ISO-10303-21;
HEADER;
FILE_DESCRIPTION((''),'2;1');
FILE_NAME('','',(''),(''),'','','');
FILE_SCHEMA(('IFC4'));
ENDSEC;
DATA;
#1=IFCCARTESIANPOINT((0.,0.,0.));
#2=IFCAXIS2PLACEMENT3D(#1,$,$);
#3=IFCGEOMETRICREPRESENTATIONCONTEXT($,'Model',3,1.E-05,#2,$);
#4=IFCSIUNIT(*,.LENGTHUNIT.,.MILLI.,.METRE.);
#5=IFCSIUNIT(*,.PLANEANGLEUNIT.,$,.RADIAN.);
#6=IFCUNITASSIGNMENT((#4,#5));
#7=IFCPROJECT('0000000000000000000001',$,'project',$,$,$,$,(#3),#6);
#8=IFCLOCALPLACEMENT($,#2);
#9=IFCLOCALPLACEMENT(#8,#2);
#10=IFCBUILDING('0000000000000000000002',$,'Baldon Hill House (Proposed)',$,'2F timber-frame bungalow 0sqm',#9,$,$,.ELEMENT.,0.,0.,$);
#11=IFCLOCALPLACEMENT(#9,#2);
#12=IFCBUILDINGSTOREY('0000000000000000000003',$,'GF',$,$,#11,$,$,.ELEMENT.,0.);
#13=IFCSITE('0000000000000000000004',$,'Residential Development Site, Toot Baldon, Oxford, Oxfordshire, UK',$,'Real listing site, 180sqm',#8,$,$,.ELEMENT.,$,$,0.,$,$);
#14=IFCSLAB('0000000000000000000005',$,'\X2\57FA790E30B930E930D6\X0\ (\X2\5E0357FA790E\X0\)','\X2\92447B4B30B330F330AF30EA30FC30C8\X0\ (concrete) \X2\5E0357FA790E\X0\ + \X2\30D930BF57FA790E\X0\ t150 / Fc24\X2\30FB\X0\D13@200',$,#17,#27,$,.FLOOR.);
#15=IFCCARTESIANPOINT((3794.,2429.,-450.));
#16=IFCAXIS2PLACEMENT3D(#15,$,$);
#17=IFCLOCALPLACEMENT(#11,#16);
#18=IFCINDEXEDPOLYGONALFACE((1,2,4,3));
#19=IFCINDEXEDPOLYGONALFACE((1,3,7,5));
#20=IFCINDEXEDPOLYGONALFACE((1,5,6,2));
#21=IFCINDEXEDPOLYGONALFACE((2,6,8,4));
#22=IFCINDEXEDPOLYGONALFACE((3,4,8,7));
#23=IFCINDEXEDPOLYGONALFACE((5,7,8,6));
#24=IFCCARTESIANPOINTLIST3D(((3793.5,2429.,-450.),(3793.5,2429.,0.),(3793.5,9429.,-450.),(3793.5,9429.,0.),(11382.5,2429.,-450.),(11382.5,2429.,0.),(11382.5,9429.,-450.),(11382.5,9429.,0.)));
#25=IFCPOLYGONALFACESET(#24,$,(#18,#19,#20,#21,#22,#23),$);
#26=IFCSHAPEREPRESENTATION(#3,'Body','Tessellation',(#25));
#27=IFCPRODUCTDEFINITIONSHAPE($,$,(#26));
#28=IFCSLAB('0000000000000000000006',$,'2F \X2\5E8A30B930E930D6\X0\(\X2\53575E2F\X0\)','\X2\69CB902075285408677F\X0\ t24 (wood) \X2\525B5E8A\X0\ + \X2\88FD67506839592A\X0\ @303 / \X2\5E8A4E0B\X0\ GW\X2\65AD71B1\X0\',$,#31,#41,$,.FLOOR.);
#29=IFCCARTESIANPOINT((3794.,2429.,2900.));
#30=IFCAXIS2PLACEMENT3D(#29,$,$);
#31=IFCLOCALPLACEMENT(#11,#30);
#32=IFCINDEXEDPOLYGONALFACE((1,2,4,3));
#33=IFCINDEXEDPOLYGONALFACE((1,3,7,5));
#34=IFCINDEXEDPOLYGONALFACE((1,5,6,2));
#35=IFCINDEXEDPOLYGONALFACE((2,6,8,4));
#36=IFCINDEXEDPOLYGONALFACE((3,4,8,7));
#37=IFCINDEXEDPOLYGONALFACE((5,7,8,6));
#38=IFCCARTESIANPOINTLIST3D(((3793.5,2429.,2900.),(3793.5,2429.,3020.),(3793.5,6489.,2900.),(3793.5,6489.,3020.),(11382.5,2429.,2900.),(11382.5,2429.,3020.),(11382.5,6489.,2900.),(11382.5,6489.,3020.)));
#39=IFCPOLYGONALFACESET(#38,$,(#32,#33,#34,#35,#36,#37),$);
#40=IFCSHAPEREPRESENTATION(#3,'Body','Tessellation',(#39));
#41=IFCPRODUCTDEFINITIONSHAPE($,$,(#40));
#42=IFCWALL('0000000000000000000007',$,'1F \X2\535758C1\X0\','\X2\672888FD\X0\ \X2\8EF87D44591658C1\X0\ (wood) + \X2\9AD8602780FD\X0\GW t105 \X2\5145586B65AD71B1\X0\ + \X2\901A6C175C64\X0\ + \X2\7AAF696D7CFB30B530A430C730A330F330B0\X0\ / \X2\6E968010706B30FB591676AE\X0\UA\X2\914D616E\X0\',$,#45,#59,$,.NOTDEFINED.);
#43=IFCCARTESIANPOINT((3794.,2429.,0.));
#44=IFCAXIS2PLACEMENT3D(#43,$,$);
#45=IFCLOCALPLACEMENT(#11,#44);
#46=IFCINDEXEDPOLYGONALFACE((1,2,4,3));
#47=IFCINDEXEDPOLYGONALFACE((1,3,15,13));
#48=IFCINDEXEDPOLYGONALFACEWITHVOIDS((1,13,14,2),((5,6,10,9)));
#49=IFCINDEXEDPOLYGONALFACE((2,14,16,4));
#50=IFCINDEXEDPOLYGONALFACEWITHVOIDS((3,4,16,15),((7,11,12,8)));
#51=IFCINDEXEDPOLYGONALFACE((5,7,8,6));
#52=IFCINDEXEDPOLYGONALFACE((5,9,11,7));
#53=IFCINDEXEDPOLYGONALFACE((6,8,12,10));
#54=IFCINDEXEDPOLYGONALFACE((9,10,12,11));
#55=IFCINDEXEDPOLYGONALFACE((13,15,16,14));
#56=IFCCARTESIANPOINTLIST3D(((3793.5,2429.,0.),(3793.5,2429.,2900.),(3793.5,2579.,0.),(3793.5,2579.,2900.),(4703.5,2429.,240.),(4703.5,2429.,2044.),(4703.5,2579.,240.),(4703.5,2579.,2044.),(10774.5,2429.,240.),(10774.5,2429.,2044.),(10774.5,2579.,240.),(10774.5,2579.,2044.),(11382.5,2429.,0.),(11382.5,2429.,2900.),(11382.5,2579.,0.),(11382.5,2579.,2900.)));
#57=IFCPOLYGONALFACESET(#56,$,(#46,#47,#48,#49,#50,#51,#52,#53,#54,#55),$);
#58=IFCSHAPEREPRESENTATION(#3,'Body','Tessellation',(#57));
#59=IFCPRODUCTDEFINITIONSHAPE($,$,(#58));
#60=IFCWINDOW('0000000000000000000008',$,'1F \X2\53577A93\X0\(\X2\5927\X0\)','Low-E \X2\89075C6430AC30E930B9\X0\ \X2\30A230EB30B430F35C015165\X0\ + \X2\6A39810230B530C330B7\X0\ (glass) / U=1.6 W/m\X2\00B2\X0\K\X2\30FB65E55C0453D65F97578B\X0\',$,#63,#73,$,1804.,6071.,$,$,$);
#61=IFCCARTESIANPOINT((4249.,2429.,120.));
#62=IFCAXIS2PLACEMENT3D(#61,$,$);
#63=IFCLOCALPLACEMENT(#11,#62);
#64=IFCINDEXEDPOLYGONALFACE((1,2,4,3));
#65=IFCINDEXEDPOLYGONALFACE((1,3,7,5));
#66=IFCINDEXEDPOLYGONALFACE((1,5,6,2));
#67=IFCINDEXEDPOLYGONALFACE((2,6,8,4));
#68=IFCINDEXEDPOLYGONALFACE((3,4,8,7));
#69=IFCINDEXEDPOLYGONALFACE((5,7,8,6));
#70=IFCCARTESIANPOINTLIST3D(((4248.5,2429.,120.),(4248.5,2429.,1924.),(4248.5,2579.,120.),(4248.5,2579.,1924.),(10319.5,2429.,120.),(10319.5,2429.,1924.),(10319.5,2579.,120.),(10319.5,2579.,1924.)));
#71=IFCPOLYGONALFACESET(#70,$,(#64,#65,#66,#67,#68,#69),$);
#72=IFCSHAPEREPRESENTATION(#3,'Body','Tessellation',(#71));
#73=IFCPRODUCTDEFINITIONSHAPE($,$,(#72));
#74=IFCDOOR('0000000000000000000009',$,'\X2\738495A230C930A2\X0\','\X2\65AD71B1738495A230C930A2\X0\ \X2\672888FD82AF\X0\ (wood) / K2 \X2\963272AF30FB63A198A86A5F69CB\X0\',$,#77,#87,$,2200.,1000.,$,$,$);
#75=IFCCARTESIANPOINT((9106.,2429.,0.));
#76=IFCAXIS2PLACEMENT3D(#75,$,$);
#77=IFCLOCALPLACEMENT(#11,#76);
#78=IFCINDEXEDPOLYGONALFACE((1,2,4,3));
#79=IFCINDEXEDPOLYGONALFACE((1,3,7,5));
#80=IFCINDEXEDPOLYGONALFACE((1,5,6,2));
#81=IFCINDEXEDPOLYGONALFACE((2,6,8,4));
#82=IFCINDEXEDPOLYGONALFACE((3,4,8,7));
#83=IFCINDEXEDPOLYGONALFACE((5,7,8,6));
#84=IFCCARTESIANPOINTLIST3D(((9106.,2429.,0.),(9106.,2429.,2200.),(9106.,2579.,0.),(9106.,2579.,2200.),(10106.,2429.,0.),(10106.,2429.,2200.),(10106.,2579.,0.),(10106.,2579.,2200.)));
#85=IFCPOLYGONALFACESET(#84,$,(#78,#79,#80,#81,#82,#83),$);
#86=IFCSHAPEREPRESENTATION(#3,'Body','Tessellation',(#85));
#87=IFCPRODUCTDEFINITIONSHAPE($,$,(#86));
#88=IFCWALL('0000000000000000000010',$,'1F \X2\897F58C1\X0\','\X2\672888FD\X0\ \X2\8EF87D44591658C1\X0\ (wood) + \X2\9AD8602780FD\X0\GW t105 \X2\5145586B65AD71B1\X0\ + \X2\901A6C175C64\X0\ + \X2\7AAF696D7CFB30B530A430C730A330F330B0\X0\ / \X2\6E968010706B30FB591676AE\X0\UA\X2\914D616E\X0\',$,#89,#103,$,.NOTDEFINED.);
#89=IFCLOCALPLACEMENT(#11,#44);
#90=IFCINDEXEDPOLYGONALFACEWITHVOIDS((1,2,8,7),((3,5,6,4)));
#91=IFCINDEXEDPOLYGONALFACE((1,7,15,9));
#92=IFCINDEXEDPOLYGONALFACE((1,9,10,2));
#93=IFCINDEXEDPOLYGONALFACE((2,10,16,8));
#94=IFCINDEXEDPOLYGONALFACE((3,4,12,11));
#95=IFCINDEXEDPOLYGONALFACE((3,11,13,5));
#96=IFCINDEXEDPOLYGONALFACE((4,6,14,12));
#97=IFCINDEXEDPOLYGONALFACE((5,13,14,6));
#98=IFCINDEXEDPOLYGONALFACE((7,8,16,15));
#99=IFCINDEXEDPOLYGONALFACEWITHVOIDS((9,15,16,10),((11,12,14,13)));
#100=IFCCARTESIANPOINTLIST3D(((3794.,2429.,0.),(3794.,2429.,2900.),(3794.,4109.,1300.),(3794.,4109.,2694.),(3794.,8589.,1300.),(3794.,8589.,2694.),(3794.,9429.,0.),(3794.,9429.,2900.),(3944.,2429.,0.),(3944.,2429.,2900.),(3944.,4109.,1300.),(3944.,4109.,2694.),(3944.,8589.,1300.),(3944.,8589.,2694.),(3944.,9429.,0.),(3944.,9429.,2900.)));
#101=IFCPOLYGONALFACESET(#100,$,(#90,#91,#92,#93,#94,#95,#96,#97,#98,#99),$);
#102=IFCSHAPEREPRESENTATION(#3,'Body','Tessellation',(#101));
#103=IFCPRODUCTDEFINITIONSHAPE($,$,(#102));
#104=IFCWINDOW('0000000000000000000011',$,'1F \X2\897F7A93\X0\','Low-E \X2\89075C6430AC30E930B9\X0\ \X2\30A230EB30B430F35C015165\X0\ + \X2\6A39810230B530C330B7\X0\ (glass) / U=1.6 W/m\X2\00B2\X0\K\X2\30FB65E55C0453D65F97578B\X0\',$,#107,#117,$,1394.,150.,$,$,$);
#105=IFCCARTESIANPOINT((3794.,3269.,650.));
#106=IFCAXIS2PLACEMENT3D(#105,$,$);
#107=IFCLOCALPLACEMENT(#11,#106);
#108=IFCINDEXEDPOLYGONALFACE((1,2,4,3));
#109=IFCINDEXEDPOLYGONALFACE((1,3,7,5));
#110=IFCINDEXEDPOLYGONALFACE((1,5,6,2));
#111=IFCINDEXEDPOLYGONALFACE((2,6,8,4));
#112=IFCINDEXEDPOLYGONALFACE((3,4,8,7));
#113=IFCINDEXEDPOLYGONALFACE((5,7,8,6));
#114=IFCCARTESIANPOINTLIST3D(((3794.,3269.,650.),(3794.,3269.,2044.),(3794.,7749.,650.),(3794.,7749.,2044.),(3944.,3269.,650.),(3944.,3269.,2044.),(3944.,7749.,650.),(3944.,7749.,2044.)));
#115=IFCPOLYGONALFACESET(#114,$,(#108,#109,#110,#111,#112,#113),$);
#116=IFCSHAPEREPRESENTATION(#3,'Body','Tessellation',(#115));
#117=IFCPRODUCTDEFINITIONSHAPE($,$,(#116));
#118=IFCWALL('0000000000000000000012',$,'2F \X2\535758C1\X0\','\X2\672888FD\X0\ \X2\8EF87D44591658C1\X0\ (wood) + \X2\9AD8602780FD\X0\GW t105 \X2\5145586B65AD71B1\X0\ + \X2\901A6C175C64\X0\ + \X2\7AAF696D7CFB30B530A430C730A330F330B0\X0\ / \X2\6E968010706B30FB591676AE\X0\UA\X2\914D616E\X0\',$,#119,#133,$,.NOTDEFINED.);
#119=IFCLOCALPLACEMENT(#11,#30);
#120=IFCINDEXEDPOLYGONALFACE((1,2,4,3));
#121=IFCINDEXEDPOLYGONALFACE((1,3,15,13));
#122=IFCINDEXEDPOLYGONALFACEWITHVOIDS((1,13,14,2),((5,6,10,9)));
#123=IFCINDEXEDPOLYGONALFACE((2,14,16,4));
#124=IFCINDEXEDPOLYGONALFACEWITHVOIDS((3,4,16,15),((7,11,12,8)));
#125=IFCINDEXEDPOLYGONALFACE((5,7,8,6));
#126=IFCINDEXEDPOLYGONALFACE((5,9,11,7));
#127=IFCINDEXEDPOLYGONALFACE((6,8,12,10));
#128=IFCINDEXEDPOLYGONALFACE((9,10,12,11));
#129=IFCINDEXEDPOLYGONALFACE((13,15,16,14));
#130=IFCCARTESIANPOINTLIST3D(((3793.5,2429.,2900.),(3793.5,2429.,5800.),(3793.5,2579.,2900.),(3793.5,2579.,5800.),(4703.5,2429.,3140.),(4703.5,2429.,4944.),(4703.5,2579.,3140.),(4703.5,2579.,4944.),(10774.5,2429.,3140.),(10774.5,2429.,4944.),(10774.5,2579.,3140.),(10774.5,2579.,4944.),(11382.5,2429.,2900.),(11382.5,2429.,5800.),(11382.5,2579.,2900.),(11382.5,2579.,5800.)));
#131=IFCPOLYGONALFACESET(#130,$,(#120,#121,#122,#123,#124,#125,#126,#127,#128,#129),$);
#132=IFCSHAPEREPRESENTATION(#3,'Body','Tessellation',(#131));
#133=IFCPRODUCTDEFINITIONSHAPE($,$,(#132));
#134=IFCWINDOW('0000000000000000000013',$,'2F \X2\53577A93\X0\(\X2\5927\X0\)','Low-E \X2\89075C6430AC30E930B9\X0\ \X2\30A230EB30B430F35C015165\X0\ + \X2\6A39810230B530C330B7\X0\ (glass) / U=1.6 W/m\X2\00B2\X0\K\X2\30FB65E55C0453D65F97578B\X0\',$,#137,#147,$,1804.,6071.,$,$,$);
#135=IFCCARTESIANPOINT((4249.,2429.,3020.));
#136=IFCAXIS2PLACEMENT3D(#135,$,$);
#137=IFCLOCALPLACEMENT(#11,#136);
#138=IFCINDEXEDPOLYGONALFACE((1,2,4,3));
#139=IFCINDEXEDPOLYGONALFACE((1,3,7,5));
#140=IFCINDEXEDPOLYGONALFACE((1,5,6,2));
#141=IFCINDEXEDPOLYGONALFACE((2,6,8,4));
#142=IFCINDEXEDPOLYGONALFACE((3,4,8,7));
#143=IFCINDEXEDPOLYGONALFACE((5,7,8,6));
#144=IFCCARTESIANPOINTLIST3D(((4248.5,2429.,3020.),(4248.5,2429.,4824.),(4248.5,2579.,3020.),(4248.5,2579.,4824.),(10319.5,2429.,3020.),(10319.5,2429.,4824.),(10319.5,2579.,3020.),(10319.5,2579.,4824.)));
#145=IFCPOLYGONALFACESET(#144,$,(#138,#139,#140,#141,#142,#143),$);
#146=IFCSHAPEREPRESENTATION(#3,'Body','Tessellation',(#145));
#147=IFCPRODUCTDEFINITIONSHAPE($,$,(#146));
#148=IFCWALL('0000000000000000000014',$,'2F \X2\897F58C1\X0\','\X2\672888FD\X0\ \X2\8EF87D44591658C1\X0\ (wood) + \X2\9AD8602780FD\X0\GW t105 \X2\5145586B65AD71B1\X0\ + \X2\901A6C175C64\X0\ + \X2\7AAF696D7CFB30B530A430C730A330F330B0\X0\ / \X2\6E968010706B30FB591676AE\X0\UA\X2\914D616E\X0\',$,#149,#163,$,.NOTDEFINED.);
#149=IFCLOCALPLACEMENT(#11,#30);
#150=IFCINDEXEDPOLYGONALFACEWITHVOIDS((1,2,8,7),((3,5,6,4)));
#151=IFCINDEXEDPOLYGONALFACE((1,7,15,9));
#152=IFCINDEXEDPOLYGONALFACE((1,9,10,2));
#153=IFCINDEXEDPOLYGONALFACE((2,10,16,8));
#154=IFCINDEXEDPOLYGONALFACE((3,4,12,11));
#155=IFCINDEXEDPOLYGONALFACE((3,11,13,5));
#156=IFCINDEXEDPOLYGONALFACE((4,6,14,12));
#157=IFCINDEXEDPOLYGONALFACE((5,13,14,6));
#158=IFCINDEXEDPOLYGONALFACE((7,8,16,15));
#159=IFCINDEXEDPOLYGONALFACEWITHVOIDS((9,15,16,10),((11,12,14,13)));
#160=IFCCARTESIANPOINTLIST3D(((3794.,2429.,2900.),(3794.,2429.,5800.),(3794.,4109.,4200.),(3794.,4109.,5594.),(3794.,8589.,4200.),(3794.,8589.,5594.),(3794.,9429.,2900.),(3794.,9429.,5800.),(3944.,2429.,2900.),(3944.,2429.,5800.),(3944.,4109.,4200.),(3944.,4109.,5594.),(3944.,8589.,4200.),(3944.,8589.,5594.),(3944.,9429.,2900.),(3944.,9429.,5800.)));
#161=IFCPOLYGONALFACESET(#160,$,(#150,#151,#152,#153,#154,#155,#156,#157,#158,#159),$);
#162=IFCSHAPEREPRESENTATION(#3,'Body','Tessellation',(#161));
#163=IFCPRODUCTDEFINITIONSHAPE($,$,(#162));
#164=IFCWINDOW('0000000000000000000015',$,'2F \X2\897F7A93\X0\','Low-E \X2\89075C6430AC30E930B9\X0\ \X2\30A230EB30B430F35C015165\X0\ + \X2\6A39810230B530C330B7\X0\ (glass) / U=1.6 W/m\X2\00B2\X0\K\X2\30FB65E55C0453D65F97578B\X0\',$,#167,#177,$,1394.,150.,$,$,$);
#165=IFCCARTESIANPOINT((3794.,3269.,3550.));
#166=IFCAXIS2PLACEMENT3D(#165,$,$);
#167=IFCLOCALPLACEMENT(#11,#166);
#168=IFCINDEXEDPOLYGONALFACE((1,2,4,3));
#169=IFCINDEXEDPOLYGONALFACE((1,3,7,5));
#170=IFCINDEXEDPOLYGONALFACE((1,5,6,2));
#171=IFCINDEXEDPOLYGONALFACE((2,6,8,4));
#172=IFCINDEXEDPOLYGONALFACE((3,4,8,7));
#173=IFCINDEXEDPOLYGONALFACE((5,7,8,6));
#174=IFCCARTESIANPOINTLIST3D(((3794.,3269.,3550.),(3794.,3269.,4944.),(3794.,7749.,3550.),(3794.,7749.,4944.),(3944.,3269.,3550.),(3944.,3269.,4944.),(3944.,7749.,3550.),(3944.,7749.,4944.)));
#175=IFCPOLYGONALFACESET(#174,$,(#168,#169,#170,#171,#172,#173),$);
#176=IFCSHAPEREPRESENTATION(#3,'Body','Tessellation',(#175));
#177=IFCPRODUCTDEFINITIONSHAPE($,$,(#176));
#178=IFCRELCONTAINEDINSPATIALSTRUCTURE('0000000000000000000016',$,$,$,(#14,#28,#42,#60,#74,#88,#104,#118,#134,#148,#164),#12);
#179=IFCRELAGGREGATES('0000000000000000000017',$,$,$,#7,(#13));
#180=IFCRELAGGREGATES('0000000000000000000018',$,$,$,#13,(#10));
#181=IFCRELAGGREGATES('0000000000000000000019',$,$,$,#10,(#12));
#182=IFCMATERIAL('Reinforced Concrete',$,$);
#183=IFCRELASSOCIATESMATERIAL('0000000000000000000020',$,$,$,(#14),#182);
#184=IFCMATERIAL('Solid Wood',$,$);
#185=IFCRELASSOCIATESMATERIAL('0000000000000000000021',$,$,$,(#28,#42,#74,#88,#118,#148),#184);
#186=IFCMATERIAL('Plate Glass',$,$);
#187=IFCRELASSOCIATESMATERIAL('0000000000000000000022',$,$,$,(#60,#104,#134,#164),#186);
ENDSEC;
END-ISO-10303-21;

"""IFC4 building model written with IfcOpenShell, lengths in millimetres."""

from ifc_helpers import new_model, si_unit, frame, frame_2d, origin, place, context, project, spatial, rectangle, extrude, material, element, fill, save


model = new_model("IFC4")

# Units and contexts
model_context = context("Model", 3, precision=1e-05, world=origin())
ifc_project = project(units=[si_unit("LENGTHUNIT", "METRE", prefix="MILLI"), si_unit("PLANEANGLEUNIT", "RADIAN")], contexts=[model_context])

# Site, building, storey
site_placement = place(None, origin())
site = spatial("IfcSite", under=ifc_project, at=site_placement, Name="Residential Development Site, Toot Baldon, Oxford, Oxfordshire, UK", ObjectType="Real listing site, 180sqm", CompositionType="ELEMENT", RefElevation=0.0)
building_placement = place(site_placement, origin())
building = spatial("IfcBuilding", under=site, at=building_placement, Name="Baldon Hill House (Proposed)", ObjectType="2F timber-frame bungalow 0sqm", CompositionType="ELEMENT", ElevationOfRefHeight=0.0, ElevationOfTerrain=0.0)
storey_placement = place(building_placement, origin())
storey = spatial("IfcBuildingStorey", under=building, at=storey_placement, Name="GF", CompositionType="ELEMENT", Elevation=0.0)

# Slabs
ifc_material_1 = material(Name="Reinforced Concrete")
slab_1_placement = place(storey_placement, frame((3794.0, 2429.0, -450.0)))
element("IfcSlab", 1, at=slab_1_placement, inside=storey, material=ifc_material_1, Name="基礎スラブ (布基礎)", Description="鉄筋コンクリート (concrete) 布基礎 + ベタ基礎 t150 / Fc24・D13@200", PredefinedType="FLOOR", context=model_context, shape_type="SweptSolid", body=[
    extrude(rectangle(XDim=7589.0, YDim=7000.0, at=frame_2d((3794.0, 3500.0))), frame((3794.0, 2429.0, -450.0)), (0.0, 0.0, 1.0), 450.0),
])
ifc_material_2 = material(Name="Solid Wood")
slab_2_placement = place(storey_placement, frame((3794.0, 2429.0, 2900.0)))
element("IfcSlab", 2, at=slab_2_placement, inside=storey, material=ifc_material_2, Name="2F 床スラブ(南帯)", Description="構造用合板 t24 (wood) 剛床 + 製材根太 @303 / 床下 GW断熱", PredefinedType="FLOOR", context=model_context, shape_type="SweptSolid", body=[
    extrude(rectangle(XDim=7589.0, YDim=4060.0, at=frame_2d((3794.0, 2030.0))), frame((3794.0, 2429.0, 2900.0)), (0.0, 0.0, 1.0), 120.0),
])

# Wall, openings, window, door
wall_1_placement = place(storey_placement, frame((3794.0, 2429.0, 0.0)))
wall_1 = element("IfcWall", 3, at=wall_1_placement, inside=storey, material=ifc_material_2, Name="1F 南壁", Description="木製 軸組外壁 (wood) + 高性能GW t105 充填断熱 + 通気層 + 窯業系サイディング / 準耐火・外皮UA配慮", PredefinedType="NOTDEFINED", context=model_context, shape_type="SweptSolid", body=[
    extrude(rectangle(XDim=7589.0, YDim=150.0, at=frame_2d((3794.0, 75.0))), frame((3794.0, 2429.0, 0.0)), (0.0, 0.0, 1.0), 2900.0),
])
opening_1_placement = place(storey_placement, frame((4249.0, 2429.0, 120.0)))
opening_1 = element("IfcOpeningElement", 4, at=opening_1_placement, cuts=wall_1, PredefinedType="NOTDEFINED", context=model_context, shape_type="SweptSolid", body=[
    extrude(rectangle(XDim=6071.0, YDim=150.0, at=frame_2d((3035.0, 75.0))), frame((4249.0, 2429.0, 120.0)), (0.0, 0.0, 1.0), 1804.0),
])
opening_2_placement = place(storey_placement, frame((9106.0, 2429.0, 0.0)))
opening_2 = element("IfcOpeningElement", 5, at=opening_2_placement, cuts=wall_1, PredefinedType="NOTDEFINED", context=model_context, shape_type="SweptSolid", body=[
    extrude(rectangle(XDim=1000.0, YDim=150.0, at=frame_2d((500.0, 75.0))), frame((9106.0, 2429.0, 0.0)), (0.0, 0.0, 1.0), 2200.0),
])
ifc_material_3 = material(Name="Plate Glass")
window_1_placement = place(storey_placement, frame((4249.0, 2429.0, 120.0)))
window_1 = element("IfcWindow", 6, at=window_1_placement, inside=storey, material=ifc_material_3, Name="1F 南窓(大)", Description="Low-E 複層ガラス アルゴン封入 + 樹脂サッシ (glass) / U=1.6 W/m²K・日射取得型", OverallHeight=1804.0, OverallWidth=6071.0, context=model_context, shape_type="SweptSolid", body=[
    extrude(rectangle(XDim=6071.0, YDim=150.0, at=frame_2d((3035.0, 75.0))), frame((4249.0, 2429.0, 120.0)), (0.0, 0.0, 1.0), 1804.0),
])
fill(opening_1, window_1)
door_placement = place(storey_placement, frame((9106.0, 2429.0, 0.0)))
door = element("IfcDoor", 7, at=door_placement, inside=storey, material=ifc_material_2, Name="玄関ドア", Description="断熱玄関ドア 木製芯 (wood) / K2 防犯・採風機構", OverallHeight=2200.0, OverallWidth=1000.0, context=model_context, shape_type="SweptSolid", body=[
    extrude(rectangle(XDim=1000.0, YDim=150.0, at=frame_2d((500.0, 75.0))), frame((9106.0, 2429.0, 0.0)), (0.0, 0.0, 1.0), 2200.0),
])
fill(opening_2, door)

# Wall, opening, window
wall_2_placement = place(storey_placement, frame((3794.0, 2429.0, 0.0)))
wall_2 = element("IfcWall", 8, at=wall_2_placement, inside=storey, material=ifc_material_2, Name="1F 西壁", Description="木製 軸組外壁 (wood) + 高性能GW t105 充填断熱 + 通気層 + 窯業系サイディング / 準耐火・外皮UA配慮", PredefinedType="NOTDEFINED", context=model_context, shape_type="SweptSolid", body=[
    extrude(rectangle(XDim=150.0, YDim=7000.0, at=frame_2d((75.0, 3500.0))), frame((3794.0, 2429.0, 0.0)), (0.0, 0.0, 1.0), 2900.0),
])
opening_3_placement = place(storey_placement, frame((3794.0, 3269.0, 650.0)))
opening_3 = element("IfcOpeningElement", 9, at=opening_3_placement, cuts=wall_2, PredefinedType="NOTDEFINED", context=model_context, shape_type="SweptSolid", body=[
    extrude(rectangle(XDim=150.0, YDim=4480.0, at=frame_2d((75.0, 2240.0))), frame((3794.0, 3269.0, 650.0)), (0.0, 0.0, 1.0), 1394.0),
])
window_2_placement = place(storey_placement, frame((3794.0, 3269.0, 650.0)))
window_2 = element("IfcWindow", 10, at=window_2_placement, inside=storey, material=ifc_material_3, Name="1F 西窓", Description="Low-E 複層ガラス アルゴン封入 + 樹脂サッシ (glass) / U=1.6 W/m²K・日射取得型", OverallHeight=1394.0, OverallWidth=150.0, context=model_context, shape_type="SweptSolid", body=[
    extrude(rectangle(XDim=150.0, YDim=4480.0, at=frame_2d((75.0, 2240.0))), frame((3794.0, 3269.0, 650.0)), (0.0, 0.0, 1.0), 1394.0),
])
fill(opening_3, window_2)

# Walls, openings, windows
wall_3_placement = place(storey_placement, frame((3794.0, 2429.0, 2900.0)))
wall_3 = element("IfcWall", 11, at=wall_3_placement, inside=storey, material=ifc_material_2, Name="2F 南壁", Description="木製 軸組外壁 (wood) + 高性能GW t105 充填断熱 + 通気層 + 窯業系サイディング / 準耐火・外皮UA配慮", PredefinedType="NOTDEFINED", context=model_context, shape_type="SweptSolid", body=[
    extrude(rectangle(XDim=7589.0, YDim=150.0, at=frame_2d((3794.0, 75.0))), frame((3794.0, 2429.0, 2900.0)), (0.0, 0.0, 1.0), 2900.0),
])
opening_4_placement = place(storey_placement, frame((4249.0, 2429.0, 3020.0)))
opening_4 = element("IfcOpeningElement", 12, at=opening_4_placement, cuts=wall_3, PredefinedType="NOTDEFINED", context=model_context, shape_type="SweptSolid", body=[
    extrude(rectangle(XDim=6071.0, YDim=150.0, at=frame_2d((3035.0, 75.0))), frame((4249.0, 2429.0, 3020.0)), (0.0, 0.0, 1.0), 1804.0),
])
window_3_placement = place(storey_placement, frame((4249.0, 2429.0, 3020.0)))
window_3 = element("IfcWindow", 13, at=window_3_placement, inside=storey, material=ifc_material_3, Name="2F 南窓(大)", Description="Low-E 複層ガラス アルゴン封入 + 樹脂サッシ (glass) / U=1.6 W/m²K・日射取得型", OverallHeight=1804.0, OverallWidth=6071.0, context=model_context, shape_type="SweptSolid", body=[
    extrude(rectangle(XDim=6071.0, YDim=150.0, at=frame_2d((3035.0, 75.0))), frame((4249.0, 2429.0, 3020.0)), (0.0, 0.0, 1.0), 1804.0),
])
fill(opening_4, window_3)
wall_4_placement = place(storey_placement, frame((3794.0, 2429.0, 2900.0)))
wall_4 = element("IfcWall", 14, at=wall_4_placement, inside=storey, material=ifc_material_2, Name="2F 西壁", Description="木製 軸組外壁 (wood) + 高性能GW t105 充填断熱 + 通気層 + 窯業系サイディング / 準耐火・外皮UA配慮", PredefinedType="NOTDEFINED", context=model_context, shape_type="SweptSolid", body=[
    extrude(rectangle(XDim=150.0, YDim=7000.0, at=frame_2d((75.0, 3500.0))), frame((3794.0, 2429.0, 2900.0)), (0.0, 0.0, 1.0), 2900.0),
])
opening_5_placement = place(storey_placement, frame((3794.0, 3269.0, 3550.0)))
opening_5 = element("IfcOpeningElement", 15, at=opening_5_placement, cuts=wall_4, PredefinedType="NOTDEFINED", context=model_context, shape_type="SweptSolid", body=[
    extrude(rectangle(XDim=150.0, YDim=4480.0, at=frame_2d((75.0, 2240.0))), frame((3794.0, 3269.0, 3550.0)), (0.0, 0.0, 1.0), 1394.0),
])
window_4_placement = place(storey_placement, frame((3794.0, 3269.0, 3550.0)))
window_4 = element("IfcWindow", 16, at=window_4_placement, inside=storey, material=ifc_material_3, Name="2F 西窓", Description="Low-E 複層ガラス アルゴン封入 + 樹脂サッシ (glass) / U=1.6 W/m²K・日射取得型", OverallHeight=1394.0, OverallWidth=150.0, context=model_context, shape_type="SweptSolid", body=[
    extrude(rectangle(XDim=150.0, YDim=4480.0, at=frame_2d((75.0, 2240.0))), frame((3794.0, 3269.0, 3550.0)), (0.0, 0.0, 1.0), 1394.0),
])
fill(opening_5, window_4)

save(model, "model.ifc")
